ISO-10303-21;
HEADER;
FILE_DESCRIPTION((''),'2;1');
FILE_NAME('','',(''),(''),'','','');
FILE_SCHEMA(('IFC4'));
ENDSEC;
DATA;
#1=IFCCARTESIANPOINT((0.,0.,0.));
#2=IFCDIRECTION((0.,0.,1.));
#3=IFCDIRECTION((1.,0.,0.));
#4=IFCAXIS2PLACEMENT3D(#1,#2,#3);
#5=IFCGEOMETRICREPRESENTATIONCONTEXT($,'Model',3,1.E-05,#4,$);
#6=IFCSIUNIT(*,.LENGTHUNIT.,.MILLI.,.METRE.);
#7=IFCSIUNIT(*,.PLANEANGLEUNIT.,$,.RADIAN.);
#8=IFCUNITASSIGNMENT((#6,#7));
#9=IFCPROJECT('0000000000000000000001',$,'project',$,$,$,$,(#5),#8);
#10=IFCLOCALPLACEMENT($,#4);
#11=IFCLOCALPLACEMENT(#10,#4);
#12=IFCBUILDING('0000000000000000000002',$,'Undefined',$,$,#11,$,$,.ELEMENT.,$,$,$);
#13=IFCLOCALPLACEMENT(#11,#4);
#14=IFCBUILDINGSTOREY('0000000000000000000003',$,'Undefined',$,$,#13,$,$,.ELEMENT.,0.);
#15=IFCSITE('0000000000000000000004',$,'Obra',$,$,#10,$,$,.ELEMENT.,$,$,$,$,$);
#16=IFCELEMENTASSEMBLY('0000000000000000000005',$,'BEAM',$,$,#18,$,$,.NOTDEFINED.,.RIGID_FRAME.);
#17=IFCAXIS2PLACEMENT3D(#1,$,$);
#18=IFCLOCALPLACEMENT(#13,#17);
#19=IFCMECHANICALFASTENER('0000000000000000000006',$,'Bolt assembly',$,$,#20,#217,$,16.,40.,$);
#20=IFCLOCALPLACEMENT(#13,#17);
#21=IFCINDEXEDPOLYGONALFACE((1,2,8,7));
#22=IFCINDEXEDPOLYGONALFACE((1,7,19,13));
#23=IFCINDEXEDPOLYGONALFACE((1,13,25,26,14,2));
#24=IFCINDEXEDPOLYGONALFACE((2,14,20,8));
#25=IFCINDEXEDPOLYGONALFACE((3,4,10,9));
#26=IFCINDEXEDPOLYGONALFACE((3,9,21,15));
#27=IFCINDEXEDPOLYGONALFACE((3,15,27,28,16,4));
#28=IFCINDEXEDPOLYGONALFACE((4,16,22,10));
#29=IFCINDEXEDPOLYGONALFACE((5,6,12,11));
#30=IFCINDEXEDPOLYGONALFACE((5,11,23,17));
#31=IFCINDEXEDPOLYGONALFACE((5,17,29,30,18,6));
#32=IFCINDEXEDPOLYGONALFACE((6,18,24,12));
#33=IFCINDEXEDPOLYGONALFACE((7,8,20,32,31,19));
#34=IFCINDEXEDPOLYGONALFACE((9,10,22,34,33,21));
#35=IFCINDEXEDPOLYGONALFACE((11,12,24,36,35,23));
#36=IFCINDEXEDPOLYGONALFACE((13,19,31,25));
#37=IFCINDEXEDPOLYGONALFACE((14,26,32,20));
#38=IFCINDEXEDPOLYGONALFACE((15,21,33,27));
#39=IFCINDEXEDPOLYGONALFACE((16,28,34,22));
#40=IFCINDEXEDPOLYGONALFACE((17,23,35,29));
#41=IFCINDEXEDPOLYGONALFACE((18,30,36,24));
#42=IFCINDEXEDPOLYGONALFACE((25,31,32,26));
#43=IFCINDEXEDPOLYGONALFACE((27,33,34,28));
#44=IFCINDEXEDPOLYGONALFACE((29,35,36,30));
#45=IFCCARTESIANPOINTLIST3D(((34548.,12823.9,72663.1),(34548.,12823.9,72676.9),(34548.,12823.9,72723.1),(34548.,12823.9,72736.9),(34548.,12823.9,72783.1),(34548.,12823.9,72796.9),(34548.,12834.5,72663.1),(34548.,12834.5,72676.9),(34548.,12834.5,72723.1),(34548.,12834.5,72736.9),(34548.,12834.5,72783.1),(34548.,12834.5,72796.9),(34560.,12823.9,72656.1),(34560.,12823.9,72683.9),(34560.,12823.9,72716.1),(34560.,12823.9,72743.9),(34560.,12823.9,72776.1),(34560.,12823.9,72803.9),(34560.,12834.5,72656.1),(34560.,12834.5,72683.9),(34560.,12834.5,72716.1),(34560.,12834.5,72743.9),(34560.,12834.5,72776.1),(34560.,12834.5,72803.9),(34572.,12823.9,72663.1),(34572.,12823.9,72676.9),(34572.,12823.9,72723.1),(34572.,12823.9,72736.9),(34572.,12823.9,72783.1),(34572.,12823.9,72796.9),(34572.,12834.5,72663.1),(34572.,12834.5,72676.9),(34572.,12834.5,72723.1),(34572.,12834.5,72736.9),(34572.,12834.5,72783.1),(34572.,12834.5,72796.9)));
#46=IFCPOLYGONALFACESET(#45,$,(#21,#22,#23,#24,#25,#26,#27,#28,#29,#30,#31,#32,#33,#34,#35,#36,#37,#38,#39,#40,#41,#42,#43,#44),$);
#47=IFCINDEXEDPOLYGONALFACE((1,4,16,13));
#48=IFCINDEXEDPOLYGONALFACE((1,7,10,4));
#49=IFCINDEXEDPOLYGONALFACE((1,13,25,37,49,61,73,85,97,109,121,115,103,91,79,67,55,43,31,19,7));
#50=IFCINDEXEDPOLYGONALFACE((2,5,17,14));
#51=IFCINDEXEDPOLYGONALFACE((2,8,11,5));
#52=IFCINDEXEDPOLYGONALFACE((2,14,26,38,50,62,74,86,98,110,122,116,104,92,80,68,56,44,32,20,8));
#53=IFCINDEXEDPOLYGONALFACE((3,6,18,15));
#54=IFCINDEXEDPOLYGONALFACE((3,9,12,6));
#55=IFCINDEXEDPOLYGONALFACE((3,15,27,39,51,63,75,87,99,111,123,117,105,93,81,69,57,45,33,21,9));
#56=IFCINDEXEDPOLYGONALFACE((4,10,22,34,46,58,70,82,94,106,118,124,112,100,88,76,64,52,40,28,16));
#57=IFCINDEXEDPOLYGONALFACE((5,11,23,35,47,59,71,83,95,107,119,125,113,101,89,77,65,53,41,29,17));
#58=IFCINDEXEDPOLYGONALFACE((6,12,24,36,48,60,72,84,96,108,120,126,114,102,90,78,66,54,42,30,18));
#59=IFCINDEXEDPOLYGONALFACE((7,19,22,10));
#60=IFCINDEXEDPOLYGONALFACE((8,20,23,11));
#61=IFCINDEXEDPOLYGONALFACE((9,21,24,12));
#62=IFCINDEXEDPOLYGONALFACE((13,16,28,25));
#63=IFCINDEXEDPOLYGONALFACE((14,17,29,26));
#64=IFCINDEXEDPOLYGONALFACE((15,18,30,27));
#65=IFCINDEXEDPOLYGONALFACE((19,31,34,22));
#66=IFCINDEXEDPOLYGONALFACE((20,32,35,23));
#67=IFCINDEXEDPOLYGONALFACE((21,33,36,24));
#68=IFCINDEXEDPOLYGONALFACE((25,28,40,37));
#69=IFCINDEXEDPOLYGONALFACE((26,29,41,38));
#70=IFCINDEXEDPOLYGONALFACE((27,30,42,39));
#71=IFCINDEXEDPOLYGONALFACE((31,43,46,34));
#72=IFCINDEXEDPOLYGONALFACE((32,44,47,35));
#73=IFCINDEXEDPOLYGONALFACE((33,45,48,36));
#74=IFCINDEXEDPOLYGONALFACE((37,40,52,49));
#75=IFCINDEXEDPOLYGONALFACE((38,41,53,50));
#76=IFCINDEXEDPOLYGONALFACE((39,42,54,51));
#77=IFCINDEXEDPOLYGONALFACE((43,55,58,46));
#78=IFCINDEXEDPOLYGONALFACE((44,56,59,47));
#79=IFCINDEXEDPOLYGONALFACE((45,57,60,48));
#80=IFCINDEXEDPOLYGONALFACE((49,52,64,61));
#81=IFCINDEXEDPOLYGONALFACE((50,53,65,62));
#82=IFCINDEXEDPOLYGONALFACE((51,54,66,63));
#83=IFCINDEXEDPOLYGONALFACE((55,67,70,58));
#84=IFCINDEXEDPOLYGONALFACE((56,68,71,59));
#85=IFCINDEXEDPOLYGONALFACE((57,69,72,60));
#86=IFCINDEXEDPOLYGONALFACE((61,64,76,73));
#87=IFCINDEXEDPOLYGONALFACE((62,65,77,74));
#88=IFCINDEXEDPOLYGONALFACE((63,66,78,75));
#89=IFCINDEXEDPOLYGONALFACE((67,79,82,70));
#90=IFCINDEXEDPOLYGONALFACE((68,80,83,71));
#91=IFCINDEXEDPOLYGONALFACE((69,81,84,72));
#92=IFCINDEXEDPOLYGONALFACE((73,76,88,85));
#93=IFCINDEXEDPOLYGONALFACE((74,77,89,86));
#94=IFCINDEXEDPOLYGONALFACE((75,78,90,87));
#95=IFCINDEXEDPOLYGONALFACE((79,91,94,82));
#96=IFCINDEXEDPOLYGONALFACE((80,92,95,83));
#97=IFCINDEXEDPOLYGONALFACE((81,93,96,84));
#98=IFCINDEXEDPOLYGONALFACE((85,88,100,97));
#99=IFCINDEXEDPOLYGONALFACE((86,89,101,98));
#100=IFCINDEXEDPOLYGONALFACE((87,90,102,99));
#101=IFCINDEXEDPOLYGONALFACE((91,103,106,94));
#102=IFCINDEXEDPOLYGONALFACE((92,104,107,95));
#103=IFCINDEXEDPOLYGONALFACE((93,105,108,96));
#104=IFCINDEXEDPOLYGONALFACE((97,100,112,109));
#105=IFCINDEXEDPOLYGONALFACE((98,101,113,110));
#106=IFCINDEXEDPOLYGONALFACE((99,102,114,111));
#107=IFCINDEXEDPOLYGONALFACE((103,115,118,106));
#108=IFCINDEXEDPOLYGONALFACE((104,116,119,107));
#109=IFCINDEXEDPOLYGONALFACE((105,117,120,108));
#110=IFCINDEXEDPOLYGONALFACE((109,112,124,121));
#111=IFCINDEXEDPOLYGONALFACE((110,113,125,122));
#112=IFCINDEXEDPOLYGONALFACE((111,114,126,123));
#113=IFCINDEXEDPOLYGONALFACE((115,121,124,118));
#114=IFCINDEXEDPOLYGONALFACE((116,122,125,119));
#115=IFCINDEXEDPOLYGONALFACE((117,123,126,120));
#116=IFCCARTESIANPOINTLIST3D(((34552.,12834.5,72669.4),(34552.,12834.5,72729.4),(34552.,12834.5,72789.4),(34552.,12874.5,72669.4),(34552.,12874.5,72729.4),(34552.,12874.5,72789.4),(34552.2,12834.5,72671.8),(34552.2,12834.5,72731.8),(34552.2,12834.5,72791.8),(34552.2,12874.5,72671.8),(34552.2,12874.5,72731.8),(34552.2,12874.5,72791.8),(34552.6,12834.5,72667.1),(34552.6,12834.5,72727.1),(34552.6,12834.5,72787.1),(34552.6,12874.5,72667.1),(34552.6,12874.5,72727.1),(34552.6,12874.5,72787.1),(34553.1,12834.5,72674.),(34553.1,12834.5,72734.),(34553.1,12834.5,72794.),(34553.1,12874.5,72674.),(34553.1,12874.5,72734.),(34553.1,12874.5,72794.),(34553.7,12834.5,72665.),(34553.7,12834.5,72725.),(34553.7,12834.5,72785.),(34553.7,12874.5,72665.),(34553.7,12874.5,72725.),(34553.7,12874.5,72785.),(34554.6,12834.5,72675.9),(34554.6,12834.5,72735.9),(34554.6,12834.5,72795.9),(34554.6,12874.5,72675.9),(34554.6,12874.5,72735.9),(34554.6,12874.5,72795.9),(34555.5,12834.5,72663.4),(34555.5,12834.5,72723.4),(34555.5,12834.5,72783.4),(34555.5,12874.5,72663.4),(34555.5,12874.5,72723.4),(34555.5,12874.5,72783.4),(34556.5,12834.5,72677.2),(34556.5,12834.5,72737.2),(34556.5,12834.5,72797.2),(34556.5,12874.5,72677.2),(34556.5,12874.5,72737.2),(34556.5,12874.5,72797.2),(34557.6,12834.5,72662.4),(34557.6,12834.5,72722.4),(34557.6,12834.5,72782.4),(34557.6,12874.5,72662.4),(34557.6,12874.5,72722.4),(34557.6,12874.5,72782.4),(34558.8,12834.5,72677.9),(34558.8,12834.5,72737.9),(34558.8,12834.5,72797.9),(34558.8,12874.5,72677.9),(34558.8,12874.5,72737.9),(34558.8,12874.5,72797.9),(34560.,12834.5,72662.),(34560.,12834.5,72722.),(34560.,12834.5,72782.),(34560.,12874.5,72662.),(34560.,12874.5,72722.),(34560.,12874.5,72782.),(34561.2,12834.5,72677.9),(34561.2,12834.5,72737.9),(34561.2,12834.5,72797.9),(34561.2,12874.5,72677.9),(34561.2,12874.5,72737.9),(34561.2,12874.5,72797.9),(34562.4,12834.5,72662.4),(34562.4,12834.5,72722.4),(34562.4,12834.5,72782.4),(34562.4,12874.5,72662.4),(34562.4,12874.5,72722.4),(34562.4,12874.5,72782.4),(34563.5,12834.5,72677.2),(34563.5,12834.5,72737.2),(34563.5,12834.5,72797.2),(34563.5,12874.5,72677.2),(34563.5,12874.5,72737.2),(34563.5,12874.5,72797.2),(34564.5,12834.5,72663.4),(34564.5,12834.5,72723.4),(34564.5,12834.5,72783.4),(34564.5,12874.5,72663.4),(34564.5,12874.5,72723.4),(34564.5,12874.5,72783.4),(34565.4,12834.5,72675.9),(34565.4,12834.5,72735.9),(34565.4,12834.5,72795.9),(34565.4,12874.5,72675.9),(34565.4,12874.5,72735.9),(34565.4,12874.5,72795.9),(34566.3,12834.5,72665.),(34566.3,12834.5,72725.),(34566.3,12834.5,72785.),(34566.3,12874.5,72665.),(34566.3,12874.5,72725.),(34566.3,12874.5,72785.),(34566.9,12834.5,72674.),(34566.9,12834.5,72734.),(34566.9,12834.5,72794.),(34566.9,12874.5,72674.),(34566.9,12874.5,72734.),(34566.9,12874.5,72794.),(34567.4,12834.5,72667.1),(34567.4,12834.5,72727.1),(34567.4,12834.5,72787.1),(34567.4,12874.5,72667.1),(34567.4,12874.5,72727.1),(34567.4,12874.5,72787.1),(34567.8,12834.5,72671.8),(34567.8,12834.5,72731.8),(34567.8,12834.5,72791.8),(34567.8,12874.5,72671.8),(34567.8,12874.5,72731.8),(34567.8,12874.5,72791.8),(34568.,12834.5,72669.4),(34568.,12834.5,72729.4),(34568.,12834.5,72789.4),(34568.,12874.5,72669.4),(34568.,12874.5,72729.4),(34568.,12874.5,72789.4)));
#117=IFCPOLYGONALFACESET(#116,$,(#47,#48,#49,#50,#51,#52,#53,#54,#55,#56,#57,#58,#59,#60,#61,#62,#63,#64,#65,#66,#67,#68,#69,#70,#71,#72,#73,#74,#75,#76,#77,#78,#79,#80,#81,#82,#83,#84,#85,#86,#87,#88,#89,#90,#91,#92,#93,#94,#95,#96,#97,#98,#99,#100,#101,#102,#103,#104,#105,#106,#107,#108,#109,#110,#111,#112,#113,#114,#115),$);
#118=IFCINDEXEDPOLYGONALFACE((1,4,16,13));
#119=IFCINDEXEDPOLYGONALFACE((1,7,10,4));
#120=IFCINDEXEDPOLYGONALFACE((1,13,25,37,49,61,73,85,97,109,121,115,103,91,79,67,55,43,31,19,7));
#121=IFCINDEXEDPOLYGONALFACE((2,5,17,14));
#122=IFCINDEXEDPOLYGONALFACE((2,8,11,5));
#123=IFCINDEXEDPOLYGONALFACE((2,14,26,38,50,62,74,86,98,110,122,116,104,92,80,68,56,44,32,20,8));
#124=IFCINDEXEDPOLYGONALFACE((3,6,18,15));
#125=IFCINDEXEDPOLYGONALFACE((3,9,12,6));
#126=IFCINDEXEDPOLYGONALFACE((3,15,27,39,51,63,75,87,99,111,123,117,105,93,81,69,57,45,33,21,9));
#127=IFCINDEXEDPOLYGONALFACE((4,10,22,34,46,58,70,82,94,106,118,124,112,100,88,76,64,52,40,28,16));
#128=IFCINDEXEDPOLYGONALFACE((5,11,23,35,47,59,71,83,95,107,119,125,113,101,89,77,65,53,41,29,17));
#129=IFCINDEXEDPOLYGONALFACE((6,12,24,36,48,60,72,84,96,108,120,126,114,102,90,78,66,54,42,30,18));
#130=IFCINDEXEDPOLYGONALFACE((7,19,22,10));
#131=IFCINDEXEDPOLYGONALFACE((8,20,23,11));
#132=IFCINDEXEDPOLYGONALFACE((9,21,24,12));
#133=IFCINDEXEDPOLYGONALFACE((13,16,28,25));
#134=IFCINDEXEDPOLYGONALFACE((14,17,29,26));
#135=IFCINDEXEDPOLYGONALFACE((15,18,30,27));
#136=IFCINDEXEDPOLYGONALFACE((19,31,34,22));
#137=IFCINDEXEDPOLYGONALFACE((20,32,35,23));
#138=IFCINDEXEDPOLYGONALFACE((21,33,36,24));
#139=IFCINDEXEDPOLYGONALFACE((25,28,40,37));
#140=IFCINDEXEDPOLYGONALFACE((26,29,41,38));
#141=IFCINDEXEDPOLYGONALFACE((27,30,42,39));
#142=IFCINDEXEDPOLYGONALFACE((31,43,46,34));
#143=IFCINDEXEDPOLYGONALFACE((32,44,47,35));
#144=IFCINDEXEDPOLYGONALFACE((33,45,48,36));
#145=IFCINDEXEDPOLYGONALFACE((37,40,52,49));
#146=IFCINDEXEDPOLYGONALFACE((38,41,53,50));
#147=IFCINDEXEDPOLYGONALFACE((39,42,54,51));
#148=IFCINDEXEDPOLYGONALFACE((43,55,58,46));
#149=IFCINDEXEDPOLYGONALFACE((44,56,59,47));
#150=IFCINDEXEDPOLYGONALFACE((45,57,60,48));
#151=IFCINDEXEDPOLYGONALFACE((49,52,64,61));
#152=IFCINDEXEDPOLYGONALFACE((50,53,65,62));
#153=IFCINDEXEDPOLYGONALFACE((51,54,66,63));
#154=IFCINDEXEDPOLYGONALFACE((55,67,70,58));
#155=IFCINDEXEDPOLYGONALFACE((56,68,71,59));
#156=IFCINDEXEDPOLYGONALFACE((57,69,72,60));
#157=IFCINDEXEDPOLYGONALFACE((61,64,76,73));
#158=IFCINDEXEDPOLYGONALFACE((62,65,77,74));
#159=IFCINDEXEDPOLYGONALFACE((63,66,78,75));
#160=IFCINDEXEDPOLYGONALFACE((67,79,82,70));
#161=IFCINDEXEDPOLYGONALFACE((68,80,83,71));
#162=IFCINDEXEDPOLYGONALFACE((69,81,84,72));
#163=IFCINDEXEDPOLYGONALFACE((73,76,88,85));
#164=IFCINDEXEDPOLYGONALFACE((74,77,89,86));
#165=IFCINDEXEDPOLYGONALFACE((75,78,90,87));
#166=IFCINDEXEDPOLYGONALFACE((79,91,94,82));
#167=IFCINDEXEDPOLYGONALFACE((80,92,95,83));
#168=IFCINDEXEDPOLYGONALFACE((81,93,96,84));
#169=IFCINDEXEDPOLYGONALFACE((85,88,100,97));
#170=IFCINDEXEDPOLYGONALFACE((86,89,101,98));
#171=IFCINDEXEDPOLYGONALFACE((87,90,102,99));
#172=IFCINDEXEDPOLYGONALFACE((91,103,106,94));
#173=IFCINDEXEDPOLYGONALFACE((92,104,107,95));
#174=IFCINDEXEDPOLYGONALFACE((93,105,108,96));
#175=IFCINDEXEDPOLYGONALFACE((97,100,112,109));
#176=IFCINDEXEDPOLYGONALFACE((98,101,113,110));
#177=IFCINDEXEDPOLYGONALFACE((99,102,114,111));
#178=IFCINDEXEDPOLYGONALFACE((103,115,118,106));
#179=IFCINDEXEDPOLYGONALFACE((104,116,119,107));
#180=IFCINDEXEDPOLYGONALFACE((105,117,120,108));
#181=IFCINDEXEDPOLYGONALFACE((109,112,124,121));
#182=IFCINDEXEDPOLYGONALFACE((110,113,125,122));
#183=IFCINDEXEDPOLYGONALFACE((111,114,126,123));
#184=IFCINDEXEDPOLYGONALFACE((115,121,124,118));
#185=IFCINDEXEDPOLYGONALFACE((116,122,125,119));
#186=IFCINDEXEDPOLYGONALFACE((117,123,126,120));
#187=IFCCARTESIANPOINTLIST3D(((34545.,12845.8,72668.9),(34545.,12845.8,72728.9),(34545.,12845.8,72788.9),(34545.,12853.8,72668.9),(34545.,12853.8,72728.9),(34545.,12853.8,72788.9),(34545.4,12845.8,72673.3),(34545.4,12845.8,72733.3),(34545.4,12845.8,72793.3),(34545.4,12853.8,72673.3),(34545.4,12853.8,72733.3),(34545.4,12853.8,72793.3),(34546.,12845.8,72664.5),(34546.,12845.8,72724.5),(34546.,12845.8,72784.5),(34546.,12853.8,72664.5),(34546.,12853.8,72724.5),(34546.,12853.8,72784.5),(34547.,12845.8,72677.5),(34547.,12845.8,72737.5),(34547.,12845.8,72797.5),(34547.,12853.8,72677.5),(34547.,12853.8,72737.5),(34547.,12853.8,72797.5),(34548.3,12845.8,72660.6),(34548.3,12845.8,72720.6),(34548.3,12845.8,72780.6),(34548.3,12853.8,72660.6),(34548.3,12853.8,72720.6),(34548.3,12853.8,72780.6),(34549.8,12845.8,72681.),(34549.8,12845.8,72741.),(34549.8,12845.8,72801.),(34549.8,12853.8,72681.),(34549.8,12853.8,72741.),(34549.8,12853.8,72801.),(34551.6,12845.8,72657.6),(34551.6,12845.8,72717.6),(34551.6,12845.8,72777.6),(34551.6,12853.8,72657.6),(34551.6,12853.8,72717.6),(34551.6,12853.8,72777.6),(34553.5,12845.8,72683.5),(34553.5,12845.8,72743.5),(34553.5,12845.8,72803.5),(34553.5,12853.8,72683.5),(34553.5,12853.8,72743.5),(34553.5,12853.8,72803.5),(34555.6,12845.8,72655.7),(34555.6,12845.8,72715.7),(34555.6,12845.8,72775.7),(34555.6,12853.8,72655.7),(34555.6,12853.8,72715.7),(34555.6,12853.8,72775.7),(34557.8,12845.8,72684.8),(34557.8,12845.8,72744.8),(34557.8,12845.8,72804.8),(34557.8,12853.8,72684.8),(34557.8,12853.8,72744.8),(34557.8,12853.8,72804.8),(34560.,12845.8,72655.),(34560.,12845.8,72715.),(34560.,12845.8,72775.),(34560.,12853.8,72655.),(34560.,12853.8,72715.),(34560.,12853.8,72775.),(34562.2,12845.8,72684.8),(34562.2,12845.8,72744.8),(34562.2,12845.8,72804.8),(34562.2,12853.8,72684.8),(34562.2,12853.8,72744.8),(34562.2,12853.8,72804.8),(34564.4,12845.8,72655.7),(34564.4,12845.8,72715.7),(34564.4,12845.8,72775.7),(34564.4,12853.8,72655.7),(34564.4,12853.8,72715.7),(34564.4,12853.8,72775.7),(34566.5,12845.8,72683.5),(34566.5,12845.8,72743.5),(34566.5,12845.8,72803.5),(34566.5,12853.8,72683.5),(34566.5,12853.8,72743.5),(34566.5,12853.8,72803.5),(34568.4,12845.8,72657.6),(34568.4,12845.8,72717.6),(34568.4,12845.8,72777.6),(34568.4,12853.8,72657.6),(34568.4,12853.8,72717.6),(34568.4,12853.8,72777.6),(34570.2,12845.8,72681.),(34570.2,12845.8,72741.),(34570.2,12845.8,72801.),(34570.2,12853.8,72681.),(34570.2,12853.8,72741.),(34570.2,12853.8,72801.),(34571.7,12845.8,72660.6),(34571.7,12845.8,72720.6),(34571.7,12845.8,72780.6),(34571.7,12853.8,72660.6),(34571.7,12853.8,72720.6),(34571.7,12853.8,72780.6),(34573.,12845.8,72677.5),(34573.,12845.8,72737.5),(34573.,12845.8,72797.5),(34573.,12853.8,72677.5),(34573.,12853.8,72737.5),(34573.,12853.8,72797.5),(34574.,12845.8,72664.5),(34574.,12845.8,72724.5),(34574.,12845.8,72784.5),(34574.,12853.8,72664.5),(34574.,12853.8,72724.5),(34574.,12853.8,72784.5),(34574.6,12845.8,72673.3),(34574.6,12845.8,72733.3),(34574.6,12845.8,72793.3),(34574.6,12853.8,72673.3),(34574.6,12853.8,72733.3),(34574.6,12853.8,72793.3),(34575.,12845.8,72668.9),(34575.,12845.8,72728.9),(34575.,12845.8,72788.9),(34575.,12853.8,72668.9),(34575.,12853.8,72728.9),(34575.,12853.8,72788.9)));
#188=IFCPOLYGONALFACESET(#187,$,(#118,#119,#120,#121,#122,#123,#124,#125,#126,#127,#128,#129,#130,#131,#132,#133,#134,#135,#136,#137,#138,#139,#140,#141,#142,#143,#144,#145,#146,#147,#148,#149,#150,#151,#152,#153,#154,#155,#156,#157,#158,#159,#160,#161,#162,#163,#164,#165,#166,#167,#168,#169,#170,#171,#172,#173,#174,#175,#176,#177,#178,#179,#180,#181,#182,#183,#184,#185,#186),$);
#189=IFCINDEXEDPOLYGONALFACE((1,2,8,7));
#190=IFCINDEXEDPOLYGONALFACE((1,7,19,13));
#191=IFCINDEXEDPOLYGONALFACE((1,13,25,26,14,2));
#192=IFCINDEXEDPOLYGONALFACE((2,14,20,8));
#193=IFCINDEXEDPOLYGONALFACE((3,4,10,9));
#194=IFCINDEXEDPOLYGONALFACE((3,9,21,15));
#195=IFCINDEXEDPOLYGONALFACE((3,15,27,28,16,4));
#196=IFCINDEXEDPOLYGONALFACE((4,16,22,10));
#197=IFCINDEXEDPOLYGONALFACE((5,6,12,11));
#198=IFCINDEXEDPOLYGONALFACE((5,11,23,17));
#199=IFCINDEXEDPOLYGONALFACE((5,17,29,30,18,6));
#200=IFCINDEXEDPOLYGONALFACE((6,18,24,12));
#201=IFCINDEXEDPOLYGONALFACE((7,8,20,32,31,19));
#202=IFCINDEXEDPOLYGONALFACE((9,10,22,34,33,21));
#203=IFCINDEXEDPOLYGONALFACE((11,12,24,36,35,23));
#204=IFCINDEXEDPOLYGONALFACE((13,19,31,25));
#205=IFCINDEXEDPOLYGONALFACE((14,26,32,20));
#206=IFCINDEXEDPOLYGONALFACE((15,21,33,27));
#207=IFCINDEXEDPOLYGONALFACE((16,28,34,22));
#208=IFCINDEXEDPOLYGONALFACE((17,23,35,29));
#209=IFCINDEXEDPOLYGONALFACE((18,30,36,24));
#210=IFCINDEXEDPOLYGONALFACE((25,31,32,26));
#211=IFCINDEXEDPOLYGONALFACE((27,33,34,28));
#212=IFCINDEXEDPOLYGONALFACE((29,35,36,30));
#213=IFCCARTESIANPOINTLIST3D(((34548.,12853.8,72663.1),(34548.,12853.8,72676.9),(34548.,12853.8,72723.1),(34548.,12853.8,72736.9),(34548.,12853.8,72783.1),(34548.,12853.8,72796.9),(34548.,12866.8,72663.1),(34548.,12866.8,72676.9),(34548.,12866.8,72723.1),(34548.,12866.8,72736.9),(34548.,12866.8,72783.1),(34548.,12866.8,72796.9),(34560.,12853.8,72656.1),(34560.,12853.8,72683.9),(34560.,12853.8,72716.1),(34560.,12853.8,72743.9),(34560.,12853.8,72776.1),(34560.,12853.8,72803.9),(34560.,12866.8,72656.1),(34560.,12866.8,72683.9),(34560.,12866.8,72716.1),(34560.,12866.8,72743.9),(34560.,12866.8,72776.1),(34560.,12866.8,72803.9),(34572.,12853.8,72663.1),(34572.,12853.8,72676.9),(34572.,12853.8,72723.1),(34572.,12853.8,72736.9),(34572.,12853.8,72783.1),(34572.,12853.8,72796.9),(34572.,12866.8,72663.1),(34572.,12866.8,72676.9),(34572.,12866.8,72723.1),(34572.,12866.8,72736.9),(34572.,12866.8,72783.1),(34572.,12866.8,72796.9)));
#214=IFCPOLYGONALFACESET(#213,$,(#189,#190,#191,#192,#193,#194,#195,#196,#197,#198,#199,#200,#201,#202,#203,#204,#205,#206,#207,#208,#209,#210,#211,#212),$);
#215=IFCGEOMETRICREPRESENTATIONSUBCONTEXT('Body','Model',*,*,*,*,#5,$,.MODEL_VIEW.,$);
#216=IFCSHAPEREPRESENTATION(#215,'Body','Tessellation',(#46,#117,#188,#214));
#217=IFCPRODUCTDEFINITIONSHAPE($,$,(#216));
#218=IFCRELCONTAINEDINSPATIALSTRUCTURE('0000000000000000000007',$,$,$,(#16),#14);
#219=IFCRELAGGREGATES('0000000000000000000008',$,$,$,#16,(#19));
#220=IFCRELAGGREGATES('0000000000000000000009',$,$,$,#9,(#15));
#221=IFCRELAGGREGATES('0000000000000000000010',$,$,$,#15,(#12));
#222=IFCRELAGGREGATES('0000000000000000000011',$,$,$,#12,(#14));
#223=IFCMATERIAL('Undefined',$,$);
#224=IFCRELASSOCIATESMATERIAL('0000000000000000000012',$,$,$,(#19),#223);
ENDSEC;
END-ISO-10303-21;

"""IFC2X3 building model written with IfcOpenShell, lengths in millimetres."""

from ifc_helpers import new_model, si_unit, frame, origin_with_axes, origin_2d_with_axis, place, context, subcontext, project, spatial, polyline, circle, outline, extrude, source, transform, mapped, material, element, aggregate, save


model = new_model("IFC2X3")

# Units and contexts
model_context = context("Model", 3, precision=1e-05, world=origin_with_axes())
body_context = subcontext(model_context, "Body", "Model", "MODEL_VIEW")
ifc_project = project(units=[si_unit("LENGTHUNIT", "METRE", prefix="MILLI"), si_unit("PLANEANGLEUNIT", "RADIAN")], contexts=[model_context])

# Site, building, storey
site_placement = place(None, origin_with_axes())
site = spatial("IfcSite", under=ifc_project, at=site_placement, Name="Obra", CompositionType="ELEMENT")
building_placement = place(site_placement, origin_with_axes())
building = spatial("IfcBuilding", under=site, at=building_placement, Name="Undefined", CompositionType="ELEMENT")
storey_placement = place(building_placement, origin_with_axes())
storey = spatial("IfcBuildingStorey", under=building, at=storey_placement, Name="Undefined", CompositionType="ELEMENT", Elevation=0.0)

# Shared definitions
ifc_material = material(Name="Undefined")

# Element assembly, mechanical fastener
assembly_1_placement = place(storey_placement, origin_with_axes())
assembly_1 = element("IfcElementAssembly", 1, at=assembly_1_placement, inside=storey, Name="BEAM", AssemblyPlace="NOTDEFINED", PredefinedType="RIGID_FRAME")
shared_shape_1 = source(origin_with_axes(), body_context, "Body", "SweptSolid", [
    extrude(outline(polyline([(13.9, 0.0), (6.9, 12.0), (-6.9, 12.0), (-13.9, 0.0), (-6.9, -12.0), (6.9, -12.0), (13.9, 0.0)])), frame((0.0, -19.7, 0.0), z_axis=(0.0, 1.0, 0.0), x_axis=(1.0, 0.0, 0.0)), (0.0, 0.0, 1.0), 10.6),
    extrude(circle(Radius=8.0, at=origin_2d_with_axis()), frame((0.0, -9.1, 0.0), z_axis=(0.0, 1.0, 0.0), x_axis=(1.0, 0.0, 0.0)), (0.0, 0.0, 1.0), 40.0),
    extrude(circle(Radius=15.0, at=origin_2d_with_axis()), frame((0.0, 2.2, 0.0), z_axis=(0.0, 1.0, 0.0), x_axis=(1.0, 0.0, 0.0)), (0.0, 0.0, 1.0), 8.0),
    extrude(outline(polyline([(13.9, 0.0), (6.9, 12.0), (-6.9, 12.0), (-13.9, 0.0), (-6.9, -12.0), (6.9, -12.0), (13.9, 0.0)])), frame((0.0, 10.2, 0.0), z_axis=(0.0, 1.0, 0.0), x_axis=(1.0, 0.0, 0.0)), (0.0, 0.0, 1.0), 13.0),
])
mechanical_fastener_1_placement = place(assembly_1_placement, frame((34510.0, 12843.6, 72850.0), z_axis=(1.0, 0.0, 0.0), x_axis=(0.0, 0.0, -1.0)))
mechanical_fastener_1 = element("IfcMechanicalFastener", 2, at=mechanical_fastener_1_placement, material=ifc_material, Name="Bolt assembly", NominalDiameter=16.0, NominalLength=40.0, context=body_context, shape_type="MappedRepresentation", body=[
    mapped(shared_shape_1, transform((60.0, 0.0, 50.0))),
    mapped(shared_shape_1, transform((120.0, 0.0, 50.0))),
    mapped(shared_shape_1, transform((180.0, 0.0, 50.0))),
])
aggregate(assembly_1, [mechanical_fastener_1])

save(model, "model.ifc")
